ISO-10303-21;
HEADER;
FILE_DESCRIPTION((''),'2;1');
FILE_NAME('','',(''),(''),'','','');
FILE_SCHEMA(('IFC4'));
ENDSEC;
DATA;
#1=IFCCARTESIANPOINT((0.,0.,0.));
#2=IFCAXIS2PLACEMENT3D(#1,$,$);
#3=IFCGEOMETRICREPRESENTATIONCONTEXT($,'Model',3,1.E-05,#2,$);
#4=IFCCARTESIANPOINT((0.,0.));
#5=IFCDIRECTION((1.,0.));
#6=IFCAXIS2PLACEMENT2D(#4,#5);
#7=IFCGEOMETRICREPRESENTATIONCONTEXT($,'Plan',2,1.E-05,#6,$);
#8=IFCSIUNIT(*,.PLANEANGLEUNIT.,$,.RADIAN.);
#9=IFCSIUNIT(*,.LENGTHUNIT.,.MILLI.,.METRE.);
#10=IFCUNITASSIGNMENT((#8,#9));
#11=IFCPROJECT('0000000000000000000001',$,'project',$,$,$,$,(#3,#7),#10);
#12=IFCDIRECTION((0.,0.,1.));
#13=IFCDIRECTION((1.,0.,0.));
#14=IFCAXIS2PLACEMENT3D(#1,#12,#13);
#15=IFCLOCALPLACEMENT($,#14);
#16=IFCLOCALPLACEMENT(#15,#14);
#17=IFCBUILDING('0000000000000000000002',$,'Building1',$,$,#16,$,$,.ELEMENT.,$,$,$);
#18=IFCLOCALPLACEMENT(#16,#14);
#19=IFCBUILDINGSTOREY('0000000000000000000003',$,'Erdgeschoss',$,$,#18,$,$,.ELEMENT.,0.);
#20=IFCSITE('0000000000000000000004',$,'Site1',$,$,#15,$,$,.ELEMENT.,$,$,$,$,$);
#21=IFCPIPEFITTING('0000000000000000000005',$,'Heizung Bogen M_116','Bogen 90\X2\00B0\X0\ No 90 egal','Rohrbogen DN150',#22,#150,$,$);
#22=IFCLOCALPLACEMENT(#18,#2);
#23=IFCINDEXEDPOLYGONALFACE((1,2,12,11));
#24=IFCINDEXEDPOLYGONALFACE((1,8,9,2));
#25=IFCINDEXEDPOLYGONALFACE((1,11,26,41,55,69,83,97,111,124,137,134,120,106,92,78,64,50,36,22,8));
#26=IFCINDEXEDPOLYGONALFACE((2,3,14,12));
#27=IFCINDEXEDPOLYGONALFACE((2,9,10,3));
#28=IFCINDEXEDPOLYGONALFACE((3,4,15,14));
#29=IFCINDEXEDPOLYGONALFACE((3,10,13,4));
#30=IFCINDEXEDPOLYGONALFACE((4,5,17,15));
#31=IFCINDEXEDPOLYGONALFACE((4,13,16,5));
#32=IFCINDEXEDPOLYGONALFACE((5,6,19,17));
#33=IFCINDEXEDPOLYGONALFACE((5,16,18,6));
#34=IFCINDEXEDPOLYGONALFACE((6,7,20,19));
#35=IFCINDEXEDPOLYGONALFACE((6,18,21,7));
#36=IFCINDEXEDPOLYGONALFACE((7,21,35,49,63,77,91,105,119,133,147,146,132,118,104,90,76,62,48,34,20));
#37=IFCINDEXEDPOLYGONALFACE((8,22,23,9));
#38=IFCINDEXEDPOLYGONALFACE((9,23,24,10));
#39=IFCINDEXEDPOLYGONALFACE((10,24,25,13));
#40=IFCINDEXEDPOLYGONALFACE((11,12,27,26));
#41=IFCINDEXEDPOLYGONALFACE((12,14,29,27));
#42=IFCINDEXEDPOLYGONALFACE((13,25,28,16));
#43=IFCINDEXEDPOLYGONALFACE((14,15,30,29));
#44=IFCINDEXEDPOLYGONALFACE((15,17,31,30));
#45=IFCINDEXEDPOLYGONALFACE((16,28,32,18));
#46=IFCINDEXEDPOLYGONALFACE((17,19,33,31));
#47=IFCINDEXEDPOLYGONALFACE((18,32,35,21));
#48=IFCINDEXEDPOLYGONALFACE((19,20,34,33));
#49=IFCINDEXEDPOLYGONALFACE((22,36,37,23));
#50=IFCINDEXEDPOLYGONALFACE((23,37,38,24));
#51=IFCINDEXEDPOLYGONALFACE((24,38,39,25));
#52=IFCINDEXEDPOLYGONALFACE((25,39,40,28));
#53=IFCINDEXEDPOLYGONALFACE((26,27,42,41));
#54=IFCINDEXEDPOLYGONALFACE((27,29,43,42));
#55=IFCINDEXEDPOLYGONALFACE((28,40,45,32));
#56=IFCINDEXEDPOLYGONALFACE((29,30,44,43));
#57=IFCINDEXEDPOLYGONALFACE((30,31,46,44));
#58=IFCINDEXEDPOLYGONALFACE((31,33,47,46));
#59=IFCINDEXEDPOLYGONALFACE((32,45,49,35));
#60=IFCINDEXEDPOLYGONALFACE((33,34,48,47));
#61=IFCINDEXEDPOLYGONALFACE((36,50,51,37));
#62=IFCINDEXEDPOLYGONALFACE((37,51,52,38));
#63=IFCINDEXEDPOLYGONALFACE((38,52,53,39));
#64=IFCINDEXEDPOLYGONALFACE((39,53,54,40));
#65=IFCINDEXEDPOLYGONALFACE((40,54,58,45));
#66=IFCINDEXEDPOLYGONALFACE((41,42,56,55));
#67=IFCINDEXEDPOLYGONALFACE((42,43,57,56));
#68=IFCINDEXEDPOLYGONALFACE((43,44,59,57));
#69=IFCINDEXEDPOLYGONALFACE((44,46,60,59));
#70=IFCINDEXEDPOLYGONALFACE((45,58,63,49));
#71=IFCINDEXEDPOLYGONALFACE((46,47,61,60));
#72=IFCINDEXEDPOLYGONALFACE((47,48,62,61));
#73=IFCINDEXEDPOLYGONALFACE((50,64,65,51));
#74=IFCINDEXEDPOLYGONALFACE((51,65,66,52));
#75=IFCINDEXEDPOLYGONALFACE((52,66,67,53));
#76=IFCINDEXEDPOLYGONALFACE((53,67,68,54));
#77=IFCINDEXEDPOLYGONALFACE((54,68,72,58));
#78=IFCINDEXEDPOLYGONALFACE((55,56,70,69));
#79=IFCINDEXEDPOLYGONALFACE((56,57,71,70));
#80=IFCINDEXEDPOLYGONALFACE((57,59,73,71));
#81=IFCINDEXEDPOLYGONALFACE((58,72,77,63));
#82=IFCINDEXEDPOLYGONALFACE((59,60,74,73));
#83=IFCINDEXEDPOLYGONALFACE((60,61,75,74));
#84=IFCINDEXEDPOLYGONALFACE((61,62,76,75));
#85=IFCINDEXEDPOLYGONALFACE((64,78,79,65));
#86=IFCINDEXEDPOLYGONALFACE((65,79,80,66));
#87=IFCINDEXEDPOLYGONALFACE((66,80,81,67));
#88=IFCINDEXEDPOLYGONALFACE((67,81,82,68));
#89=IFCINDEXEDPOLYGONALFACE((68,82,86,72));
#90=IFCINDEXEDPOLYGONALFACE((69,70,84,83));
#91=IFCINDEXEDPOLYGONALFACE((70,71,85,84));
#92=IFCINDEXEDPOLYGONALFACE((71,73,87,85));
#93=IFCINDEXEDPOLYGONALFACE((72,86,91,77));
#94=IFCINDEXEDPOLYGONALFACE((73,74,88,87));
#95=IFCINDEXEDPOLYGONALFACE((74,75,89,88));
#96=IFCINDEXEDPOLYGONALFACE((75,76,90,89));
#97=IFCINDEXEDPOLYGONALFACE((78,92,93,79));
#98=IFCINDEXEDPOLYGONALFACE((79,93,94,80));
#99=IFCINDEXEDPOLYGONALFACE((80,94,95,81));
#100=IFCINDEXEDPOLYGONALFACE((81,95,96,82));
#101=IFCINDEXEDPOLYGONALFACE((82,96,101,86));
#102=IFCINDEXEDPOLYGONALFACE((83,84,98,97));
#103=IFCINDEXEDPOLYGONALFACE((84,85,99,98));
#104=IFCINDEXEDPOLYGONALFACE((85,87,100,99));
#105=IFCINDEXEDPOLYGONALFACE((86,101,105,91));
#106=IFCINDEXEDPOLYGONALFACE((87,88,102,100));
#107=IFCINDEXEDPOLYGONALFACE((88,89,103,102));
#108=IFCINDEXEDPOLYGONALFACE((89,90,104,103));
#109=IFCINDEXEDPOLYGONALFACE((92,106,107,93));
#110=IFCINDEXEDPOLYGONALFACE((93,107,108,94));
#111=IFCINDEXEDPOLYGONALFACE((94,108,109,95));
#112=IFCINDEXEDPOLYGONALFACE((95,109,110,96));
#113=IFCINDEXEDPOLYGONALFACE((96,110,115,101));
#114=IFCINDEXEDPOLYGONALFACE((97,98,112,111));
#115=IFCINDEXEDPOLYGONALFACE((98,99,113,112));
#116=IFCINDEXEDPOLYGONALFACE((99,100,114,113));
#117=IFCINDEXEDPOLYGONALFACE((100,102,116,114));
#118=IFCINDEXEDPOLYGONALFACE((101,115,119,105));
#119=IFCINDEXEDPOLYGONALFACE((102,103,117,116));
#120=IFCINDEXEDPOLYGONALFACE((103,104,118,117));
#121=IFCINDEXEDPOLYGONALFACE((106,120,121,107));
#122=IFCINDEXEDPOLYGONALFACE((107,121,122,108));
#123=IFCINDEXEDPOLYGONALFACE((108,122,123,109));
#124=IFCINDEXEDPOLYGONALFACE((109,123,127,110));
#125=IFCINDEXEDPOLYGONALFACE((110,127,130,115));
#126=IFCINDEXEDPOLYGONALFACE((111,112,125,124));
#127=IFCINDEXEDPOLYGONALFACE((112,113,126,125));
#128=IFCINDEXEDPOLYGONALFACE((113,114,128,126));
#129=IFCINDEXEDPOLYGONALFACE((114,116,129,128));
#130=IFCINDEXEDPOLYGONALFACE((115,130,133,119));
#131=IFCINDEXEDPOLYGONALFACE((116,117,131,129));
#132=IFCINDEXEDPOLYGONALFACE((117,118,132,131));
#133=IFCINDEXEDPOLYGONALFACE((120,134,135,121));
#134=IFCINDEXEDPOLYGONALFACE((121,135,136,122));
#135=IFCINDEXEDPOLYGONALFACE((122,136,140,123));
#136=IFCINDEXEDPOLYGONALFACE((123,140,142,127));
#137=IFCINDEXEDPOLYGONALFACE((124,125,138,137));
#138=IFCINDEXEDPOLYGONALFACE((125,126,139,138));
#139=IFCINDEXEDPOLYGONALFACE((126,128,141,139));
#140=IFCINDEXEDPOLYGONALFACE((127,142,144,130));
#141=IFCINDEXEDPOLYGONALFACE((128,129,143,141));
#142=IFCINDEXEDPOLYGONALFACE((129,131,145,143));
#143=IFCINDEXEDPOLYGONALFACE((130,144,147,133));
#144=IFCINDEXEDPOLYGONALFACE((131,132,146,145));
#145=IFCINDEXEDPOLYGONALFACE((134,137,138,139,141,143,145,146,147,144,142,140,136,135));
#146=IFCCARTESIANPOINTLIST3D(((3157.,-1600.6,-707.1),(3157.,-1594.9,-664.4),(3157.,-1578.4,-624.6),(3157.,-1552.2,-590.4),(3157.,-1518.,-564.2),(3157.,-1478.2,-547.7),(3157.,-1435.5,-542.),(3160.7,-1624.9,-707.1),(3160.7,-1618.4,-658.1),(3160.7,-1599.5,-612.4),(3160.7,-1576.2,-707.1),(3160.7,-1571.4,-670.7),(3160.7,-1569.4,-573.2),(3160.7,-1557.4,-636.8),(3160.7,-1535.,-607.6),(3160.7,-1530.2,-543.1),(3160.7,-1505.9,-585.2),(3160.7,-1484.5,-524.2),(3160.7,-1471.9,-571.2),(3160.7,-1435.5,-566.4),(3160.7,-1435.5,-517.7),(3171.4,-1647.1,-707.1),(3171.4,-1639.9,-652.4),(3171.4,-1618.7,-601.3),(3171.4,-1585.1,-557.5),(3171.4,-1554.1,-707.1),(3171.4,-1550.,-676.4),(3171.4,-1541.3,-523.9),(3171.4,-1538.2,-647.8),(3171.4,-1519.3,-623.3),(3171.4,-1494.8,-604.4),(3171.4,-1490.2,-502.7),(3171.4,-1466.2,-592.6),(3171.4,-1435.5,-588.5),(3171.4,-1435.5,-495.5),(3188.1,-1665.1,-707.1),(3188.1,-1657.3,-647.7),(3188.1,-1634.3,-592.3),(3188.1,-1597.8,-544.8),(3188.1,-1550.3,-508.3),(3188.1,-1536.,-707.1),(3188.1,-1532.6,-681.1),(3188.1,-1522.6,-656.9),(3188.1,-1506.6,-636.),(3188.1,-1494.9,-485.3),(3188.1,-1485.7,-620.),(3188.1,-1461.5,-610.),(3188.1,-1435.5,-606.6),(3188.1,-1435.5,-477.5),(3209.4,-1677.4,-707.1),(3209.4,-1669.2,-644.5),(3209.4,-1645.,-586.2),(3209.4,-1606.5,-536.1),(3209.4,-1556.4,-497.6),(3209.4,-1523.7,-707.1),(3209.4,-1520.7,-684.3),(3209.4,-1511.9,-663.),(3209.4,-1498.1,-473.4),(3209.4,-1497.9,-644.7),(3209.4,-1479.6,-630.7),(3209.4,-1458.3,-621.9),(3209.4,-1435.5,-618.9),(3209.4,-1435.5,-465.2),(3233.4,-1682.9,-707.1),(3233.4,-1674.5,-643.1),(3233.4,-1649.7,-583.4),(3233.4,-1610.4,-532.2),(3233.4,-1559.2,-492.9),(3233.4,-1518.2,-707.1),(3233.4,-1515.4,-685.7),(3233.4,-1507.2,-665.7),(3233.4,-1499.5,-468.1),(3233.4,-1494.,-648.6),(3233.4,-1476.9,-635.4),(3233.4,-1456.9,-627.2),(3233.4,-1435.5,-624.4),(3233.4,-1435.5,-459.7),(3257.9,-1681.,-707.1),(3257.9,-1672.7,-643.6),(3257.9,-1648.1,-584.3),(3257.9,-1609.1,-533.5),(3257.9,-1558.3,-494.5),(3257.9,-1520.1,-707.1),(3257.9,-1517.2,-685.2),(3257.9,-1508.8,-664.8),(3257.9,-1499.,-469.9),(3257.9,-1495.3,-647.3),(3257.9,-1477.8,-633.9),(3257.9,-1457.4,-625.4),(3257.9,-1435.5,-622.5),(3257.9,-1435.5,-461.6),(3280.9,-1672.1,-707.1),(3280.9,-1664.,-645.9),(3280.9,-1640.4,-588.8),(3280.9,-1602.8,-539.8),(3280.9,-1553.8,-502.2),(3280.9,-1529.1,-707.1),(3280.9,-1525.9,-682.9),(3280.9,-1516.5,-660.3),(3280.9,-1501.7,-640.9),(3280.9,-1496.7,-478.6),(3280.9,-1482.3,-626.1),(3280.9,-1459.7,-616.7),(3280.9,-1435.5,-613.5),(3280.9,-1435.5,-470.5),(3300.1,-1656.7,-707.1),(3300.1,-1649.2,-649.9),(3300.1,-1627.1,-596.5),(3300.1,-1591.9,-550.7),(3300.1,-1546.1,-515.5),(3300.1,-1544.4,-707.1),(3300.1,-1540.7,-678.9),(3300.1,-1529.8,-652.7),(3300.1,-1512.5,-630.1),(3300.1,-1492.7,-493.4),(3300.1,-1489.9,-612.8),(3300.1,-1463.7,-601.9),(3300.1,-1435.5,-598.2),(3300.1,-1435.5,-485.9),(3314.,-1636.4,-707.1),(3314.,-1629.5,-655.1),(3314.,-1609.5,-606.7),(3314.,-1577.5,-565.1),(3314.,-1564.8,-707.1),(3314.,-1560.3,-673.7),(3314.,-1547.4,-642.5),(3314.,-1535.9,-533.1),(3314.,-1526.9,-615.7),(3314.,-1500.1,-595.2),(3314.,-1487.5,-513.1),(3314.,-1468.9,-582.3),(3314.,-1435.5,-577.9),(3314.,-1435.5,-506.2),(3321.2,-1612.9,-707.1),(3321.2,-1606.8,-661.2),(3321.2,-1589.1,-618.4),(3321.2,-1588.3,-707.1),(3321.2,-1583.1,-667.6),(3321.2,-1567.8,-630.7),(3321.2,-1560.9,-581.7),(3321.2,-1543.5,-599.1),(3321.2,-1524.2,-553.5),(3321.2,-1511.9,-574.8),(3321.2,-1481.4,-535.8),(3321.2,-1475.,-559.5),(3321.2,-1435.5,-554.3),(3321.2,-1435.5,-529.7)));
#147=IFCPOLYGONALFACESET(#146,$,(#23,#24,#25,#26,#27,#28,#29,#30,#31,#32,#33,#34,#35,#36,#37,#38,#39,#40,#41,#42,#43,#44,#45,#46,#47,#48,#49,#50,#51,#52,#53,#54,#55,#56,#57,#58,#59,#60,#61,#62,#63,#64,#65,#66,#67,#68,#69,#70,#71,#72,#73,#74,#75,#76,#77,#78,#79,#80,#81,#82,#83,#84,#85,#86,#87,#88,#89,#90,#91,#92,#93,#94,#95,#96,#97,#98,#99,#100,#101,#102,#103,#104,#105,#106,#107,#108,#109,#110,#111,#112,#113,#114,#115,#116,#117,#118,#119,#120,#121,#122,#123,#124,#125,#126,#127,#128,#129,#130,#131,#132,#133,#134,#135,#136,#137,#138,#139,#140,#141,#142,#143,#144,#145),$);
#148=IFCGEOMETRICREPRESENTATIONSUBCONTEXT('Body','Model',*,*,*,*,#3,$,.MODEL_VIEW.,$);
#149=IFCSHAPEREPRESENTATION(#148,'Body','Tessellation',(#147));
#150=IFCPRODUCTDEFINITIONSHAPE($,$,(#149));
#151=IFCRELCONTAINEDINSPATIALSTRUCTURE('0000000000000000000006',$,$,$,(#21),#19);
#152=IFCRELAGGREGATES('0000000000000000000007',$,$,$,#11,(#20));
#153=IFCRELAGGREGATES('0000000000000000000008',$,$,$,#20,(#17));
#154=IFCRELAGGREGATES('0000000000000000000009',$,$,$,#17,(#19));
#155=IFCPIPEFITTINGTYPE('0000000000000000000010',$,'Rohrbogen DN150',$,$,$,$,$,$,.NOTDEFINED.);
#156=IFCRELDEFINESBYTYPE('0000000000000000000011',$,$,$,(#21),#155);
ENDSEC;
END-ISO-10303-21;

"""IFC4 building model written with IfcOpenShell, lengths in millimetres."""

from ifc_helpers import new_model, entity, si_unit, frame, origin, origin_with_axes, origin_2d_with_axis, place, context, subcontext, project, spatial, source, transform, mapped, type_object, element, save


model = new_model("IFC4")

# Units and contexts
model_context = context("Model", 3, precision=1e-05, world=origin())
plan_context = context("Plan", 2, precision=1e-05, world=origin_2d_with_axis())
body_context = subcontext(model_context, "Body", "Model", "MODEL_VIEW")
ifc_project = project(units=[si_unit("PLANEANGLEUNIT", "RADIAN"), si_unit("LENGTHUNIT", "METRE", prefix="MILLI")], contexts=[model_context, plan_context])

# Site, building, storey
site_placement = place(None, origin_with_axes())
site = spatial("IfcSite", under=ifc_project, at=site_placement, Name="Site1", CompositionType="ELEMENT")
building_placement = place(site_placement, origin_with_axes())
building = spatial("IfcBuilding", under=site, at=building_placement, Name="Building1", CompositionType="ELEMENT")
storey_placement = place(building_placement, origin_with_axes())
storey = spatial("IfcBuildingStorey", under=building, at=storey_placement, Name="Erdgeschoss", CompositionType="ELEMENT", Elevation=0.0)

# Pipe fitting
pipe_fitting_type_1 = type_object("IfcPipeFittingType", Name="Rohrbogen DN150", PredefinedType="NOTDEFINED")
shared_shape_1 = source(origin_with_axes(), body_context, "Body", "SolidModel", [
    entity("IfcRevolvedAreaSolid", entity("IfcCircleProfileDef", "AREA", None, entity("IfcAxis2Placement2D", entity("IfcCartesianPoint", [0.0, 0.0]), entity("IfcDirection", [1.0, 0.0])), 82.5), entity("IfcAxis2Placement3D", entity("IfcCartesianPoint", [-123.8, 0.0, 41.3]), entity("IfcDirection", [1.0, 0.0, 0.0]), entity("IfcDirection", [0.0, -1.0, 0.0])), entity("IfcAxis1Placement", entity("IfcCartesianPoint", [0.0, 165.1, 0.0]), entity("IfcDirection", [-1.0, 0.0, 0.0])), 1.570796),
])
pipe_fitting_1_placement = place(storey_placement, frame((3239.6, -1559.3, -583.3), z_axis=(0.0, 0.0, 1.0), x_axis=(1.0, 0.0, 0.0)))
element("IfcPipeFitting", 1, at=pipe_fitting_1_placement, inside=storey, type_object=pipe_fitting_type_1, Name="Heizung Bogen M_116", Description="Bogen 90° No 90 egal", ObjectType="Rohrbogen DN150", context=body_context, shape_type="MappedRepresentation", body=[
    mapped(shared_shape_1, transform((0.0, 0.0, 0.0), x_axis=(0.0, -1.0, 0.0), y_axis=(1.0, 0.0, 0.0), z_axis=(0.0, 0.0, 1.0), scale=1.0)),
])

save(model, "model.ifc")
